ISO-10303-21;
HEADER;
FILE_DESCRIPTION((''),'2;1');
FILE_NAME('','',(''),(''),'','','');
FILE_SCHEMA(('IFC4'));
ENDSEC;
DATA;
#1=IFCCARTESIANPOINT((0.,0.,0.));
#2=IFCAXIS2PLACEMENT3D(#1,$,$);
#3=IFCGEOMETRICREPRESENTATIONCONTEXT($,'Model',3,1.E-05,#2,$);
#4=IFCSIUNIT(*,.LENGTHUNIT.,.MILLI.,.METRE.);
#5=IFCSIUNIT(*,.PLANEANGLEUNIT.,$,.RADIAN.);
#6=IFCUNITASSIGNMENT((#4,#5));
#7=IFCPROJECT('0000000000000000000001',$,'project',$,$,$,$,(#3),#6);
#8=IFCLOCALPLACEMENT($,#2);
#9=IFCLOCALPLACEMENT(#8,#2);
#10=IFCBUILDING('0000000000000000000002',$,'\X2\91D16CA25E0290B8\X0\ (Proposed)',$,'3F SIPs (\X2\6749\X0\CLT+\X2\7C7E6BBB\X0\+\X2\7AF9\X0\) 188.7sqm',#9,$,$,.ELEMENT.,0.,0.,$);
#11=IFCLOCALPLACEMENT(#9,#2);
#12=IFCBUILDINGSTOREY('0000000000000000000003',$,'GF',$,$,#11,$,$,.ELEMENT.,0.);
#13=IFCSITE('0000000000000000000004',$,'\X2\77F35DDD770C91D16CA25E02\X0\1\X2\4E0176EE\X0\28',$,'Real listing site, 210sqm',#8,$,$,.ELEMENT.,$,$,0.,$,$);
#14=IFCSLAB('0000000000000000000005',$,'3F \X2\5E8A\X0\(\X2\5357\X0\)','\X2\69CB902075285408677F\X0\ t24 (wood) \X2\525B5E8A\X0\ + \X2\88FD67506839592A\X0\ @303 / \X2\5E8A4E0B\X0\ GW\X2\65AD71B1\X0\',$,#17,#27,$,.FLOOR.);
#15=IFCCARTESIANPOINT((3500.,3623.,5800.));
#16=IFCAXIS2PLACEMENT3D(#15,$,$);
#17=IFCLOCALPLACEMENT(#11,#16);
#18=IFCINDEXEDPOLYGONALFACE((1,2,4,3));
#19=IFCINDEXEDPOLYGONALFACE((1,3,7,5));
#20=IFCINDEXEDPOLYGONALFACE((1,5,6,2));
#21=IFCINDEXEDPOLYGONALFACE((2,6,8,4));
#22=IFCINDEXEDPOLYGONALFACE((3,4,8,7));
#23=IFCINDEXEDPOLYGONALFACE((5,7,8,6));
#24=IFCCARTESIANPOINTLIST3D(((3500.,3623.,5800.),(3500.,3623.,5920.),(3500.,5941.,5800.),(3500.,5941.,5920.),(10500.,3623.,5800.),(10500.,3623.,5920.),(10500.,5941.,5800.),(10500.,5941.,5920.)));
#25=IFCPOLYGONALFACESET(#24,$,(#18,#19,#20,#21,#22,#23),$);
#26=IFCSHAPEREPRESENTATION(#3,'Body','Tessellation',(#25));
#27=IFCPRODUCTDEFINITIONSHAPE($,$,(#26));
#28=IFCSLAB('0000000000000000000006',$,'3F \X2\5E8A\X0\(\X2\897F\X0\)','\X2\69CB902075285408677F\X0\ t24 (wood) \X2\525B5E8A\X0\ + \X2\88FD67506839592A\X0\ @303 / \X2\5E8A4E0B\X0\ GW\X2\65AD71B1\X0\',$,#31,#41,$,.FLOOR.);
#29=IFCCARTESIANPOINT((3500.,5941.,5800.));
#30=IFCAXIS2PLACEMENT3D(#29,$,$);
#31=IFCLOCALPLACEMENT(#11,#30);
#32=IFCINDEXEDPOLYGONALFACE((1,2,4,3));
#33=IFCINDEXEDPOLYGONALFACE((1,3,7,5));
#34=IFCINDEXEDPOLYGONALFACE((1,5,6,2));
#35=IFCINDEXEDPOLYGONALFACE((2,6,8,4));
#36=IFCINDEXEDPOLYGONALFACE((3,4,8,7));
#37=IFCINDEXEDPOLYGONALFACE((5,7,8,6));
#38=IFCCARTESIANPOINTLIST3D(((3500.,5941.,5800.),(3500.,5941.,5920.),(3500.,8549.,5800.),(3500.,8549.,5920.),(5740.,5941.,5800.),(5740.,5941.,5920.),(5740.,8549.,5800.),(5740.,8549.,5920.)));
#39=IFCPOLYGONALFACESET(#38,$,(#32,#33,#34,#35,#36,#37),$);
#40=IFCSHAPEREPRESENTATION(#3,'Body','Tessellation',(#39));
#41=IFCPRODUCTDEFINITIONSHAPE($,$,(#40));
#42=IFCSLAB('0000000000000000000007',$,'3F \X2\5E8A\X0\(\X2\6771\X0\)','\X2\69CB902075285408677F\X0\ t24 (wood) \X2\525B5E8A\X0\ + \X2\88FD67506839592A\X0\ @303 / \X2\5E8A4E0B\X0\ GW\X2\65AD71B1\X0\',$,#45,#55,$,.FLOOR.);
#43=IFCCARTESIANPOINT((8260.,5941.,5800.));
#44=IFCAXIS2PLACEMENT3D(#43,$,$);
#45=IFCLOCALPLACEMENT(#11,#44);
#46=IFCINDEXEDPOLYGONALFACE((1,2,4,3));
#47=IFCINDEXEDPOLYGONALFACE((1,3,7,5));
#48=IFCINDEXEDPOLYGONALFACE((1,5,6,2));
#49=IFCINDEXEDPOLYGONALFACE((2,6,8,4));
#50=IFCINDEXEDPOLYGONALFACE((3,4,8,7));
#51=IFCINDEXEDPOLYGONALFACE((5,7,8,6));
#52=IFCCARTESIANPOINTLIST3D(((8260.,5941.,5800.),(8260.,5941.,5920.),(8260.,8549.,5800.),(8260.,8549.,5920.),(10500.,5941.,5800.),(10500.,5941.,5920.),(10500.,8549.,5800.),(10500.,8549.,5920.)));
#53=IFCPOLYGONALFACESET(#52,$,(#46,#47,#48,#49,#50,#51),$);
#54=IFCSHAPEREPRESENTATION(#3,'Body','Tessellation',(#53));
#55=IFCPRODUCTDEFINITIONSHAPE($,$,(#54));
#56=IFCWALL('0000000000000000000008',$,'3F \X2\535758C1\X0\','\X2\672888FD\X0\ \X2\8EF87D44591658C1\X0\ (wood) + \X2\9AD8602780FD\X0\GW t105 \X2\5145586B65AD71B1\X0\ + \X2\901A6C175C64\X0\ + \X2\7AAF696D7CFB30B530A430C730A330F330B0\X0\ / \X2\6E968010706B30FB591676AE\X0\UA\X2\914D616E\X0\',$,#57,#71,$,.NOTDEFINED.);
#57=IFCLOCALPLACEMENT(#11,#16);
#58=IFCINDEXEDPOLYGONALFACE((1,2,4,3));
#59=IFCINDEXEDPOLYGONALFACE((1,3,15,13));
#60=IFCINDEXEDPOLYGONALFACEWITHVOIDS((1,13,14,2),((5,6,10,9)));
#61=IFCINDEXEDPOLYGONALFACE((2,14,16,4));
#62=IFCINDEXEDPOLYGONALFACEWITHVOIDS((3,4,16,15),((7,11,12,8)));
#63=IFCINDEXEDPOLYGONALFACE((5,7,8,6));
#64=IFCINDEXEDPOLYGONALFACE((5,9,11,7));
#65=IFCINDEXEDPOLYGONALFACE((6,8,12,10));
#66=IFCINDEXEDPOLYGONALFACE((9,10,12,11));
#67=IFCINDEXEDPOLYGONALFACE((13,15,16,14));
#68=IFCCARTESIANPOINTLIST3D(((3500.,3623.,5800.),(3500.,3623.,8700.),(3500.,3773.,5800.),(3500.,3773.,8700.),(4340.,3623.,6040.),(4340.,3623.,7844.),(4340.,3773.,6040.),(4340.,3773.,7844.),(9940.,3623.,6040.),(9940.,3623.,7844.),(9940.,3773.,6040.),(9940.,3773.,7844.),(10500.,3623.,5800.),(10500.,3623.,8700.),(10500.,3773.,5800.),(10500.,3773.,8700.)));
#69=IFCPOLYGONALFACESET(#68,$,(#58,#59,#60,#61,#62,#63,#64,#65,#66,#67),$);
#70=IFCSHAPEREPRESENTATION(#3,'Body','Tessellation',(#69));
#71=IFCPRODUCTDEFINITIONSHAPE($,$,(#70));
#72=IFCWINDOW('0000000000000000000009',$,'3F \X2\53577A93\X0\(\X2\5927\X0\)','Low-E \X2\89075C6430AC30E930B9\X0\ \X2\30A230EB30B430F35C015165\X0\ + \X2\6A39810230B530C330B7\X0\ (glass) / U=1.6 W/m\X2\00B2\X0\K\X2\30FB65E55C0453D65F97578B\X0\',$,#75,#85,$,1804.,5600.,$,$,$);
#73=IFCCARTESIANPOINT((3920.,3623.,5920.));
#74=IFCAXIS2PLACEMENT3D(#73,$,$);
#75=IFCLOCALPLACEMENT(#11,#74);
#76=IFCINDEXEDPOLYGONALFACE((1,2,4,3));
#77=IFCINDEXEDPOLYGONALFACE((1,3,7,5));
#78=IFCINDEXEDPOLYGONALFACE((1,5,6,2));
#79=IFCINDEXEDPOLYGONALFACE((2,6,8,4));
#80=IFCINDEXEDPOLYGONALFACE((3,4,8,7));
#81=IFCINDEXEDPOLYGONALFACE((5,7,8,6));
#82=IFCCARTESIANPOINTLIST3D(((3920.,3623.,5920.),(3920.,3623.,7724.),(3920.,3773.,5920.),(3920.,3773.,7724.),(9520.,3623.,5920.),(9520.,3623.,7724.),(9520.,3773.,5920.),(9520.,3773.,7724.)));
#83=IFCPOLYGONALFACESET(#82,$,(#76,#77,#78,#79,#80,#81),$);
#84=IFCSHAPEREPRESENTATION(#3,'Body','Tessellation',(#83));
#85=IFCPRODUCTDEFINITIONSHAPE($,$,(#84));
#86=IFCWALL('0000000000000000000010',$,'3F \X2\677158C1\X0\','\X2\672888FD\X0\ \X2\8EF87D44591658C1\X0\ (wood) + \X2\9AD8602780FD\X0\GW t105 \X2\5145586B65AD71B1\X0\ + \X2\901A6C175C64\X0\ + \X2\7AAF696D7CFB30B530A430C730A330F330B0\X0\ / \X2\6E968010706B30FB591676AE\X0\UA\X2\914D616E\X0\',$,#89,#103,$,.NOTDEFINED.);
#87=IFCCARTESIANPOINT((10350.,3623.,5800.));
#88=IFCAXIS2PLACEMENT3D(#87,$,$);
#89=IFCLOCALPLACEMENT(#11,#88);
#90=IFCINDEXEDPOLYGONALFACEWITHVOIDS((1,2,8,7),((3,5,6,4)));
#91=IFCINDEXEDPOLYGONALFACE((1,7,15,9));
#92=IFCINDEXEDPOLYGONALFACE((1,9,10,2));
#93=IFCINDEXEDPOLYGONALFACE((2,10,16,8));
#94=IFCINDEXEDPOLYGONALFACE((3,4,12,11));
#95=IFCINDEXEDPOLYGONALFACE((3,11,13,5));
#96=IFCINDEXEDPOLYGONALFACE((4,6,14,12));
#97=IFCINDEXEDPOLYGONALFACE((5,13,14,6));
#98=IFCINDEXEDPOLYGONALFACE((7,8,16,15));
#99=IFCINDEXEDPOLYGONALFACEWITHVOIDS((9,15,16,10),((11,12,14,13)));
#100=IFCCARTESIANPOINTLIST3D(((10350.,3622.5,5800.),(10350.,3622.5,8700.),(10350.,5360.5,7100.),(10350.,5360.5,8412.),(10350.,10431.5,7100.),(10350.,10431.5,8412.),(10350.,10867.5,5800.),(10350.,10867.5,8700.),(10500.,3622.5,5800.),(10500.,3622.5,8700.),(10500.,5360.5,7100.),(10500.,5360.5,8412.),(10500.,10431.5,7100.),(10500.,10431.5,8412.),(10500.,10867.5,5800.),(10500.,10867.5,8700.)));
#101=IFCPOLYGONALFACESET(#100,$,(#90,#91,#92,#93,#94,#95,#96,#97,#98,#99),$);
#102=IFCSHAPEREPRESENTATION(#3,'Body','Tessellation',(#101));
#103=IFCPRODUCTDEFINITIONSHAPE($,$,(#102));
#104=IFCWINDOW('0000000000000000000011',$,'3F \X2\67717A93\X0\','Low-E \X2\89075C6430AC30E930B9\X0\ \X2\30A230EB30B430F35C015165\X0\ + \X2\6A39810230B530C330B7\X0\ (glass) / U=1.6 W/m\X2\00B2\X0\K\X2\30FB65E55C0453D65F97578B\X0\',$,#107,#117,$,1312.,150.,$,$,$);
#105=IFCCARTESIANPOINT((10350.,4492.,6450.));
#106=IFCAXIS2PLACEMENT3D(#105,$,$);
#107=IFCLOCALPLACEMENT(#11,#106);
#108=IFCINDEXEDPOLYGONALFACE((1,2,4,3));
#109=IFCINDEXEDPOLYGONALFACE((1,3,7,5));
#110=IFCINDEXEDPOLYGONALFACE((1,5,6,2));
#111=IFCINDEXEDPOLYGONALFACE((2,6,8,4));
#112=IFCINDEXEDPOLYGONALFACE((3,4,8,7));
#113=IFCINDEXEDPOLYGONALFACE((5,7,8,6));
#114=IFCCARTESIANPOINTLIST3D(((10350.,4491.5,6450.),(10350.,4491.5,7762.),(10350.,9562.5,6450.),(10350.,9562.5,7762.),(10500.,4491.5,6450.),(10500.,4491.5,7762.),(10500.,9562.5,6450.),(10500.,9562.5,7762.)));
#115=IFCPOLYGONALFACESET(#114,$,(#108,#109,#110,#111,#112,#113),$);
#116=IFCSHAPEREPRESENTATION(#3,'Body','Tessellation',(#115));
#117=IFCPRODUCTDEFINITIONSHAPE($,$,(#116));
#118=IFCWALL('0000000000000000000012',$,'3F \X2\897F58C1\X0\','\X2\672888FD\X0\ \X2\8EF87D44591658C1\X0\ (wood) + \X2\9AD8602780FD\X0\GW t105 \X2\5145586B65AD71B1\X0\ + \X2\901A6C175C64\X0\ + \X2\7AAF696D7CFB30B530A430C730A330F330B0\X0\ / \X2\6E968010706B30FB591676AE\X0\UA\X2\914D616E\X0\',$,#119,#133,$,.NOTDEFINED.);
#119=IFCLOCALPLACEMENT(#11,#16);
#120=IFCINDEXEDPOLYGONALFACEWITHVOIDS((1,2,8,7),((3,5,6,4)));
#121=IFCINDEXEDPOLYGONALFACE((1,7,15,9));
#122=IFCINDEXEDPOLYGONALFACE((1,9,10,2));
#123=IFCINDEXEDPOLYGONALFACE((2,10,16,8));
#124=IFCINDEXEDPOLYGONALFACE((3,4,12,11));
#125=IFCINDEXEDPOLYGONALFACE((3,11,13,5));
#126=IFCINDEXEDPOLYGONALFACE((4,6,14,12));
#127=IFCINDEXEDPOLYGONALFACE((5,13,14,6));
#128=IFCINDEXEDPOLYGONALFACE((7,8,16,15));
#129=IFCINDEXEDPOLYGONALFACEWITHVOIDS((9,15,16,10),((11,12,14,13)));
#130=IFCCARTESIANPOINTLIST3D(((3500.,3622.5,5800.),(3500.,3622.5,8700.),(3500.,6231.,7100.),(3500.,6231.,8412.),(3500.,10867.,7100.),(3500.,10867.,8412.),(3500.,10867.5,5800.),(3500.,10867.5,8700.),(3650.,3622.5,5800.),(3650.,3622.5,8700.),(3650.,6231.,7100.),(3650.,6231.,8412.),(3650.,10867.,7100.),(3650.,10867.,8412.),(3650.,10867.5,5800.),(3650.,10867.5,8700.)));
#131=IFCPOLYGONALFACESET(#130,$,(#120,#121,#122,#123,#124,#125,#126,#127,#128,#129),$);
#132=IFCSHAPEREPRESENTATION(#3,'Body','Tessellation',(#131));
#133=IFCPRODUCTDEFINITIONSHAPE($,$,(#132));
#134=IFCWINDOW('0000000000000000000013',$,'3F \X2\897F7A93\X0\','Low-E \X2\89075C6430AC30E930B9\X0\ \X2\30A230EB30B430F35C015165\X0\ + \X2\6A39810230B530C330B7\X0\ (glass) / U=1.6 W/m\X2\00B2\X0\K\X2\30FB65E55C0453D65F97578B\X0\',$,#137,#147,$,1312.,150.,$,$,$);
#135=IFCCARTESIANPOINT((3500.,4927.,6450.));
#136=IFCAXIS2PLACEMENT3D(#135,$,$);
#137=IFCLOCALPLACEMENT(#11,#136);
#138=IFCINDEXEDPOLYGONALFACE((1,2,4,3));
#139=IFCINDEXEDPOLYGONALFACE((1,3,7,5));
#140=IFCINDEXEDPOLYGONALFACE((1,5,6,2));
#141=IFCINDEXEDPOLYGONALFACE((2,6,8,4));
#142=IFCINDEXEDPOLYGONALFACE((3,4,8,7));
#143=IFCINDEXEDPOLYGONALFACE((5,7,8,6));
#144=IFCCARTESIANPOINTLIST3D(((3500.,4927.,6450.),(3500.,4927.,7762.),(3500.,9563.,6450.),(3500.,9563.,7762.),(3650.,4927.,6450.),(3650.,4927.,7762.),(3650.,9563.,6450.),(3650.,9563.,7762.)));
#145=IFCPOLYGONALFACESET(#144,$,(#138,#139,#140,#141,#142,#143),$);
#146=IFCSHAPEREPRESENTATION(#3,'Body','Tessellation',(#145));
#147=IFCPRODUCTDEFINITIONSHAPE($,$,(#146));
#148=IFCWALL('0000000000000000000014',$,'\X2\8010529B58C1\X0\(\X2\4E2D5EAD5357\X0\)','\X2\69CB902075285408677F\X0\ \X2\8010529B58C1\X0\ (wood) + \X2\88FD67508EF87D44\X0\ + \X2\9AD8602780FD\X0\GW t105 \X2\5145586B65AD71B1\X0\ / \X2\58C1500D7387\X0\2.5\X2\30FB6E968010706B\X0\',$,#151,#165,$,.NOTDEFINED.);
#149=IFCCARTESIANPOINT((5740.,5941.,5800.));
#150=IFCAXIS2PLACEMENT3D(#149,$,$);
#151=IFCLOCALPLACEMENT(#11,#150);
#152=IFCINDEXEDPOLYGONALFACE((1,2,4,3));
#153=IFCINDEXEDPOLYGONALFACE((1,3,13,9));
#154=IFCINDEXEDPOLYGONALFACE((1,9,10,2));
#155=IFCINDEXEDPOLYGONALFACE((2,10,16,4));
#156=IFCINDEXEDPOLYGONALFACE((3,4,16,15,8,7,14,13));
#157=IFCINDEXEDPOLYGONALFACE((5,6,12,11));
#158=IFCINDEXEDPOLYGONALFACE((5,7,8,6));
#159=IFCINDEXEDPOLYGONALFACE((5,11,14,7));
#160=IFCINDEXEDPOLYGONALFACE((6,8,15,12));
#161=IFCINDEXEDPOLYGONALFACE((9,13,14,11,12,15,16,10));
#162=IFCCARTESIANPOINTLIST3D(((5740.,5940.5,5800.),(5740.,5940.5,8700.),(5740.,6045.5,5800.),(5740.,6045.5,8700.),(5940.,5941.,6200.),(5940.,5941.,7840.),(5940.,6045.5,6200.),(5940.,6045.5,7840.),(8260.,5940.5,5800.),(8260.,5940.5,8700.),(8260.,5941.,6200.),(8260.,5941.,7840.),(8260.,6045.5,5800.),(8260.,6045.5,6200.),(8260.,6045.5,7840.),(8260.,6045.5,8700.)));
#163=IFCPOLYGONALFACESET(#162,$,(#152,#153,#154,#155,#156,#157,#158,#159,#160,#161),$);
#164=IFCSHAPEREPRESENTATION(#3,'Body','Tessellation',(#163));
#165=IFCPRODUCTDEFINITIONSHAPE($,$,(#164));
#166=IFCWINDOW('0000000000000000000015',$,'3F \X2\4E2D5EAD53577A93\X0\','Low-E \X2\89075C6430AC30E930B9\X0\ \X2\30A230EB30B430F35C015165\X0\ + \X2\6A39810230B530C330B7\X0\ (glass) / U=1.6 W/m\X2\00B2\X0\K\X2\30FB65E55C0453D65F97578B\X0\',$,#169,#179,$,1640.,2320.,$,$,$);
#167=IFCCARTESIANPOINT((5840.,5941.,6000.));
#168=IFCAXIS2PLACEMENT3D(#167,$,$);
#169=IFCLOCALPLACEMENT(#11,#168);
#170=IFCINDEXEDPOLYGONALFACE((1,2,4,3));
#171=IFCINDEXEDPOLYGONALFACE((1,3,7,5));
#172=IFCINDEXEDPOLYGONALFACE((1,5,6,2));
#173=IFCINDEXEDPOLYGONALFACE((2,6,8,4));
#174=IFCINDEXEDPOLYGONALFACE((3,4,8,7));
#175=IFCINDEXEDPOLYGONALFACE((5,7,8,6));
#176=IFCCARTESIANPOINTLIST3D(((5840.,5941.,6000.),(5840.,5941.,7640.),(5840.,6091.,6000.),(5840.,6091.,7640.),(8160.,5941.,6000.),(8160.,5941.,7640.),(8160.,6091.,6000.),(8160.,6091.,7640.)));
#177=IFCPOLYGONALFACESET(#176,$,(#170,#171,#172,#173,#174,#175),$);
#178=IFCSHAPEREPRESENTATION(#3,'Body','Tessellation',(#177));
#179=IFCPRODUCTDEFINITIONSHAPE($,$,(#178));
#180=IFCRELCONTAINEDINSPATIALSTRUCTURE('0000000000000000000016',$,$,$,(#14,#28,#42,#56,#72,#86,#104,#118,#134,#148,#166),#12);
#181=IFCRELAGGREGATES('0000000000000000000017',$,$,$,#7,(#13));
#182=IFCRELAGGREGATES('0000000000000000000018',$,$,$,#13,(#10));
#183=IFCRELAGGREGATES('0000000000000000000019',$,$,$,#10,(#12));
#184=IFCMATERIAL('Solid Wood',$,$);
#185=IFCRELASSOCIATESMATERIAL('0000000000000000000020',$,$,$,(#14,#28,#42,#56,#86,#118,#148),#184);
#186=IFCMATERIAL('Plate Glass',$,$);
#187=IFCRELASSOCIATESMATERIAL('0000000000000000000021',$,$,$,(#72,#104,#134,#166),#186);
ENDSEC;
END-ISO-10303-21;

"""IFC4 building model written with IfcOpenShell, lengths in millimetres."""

from ifc_helpers import new_model, si_unit, frame, frame_2d, origin, place, context, project, spatial, rectangle, extrude, material, element, fill, save


model = new_model("IFC4")

# Units and contexts
model_context = context("Model", 3, precision=1e-05, world=origin())
ifc_project = project(units=[si_unit("LENGTHUNIT", "METRE", prefix="MILLI"), si_unit("PLANEANGLEUNIT", "RADIAN")], contexts=[model_context])

# Site, building, storey
site_placement = place(None, origin())
site = spatial("IfcSite", under=ifc_project, at=site_placement, Name="石川県金沢市1丁目28", ObjectType="Real listing site, 210sqm", CompositionType="ELEMENT", RefElevation=0.0)
building_placement = place(site_placement, origin())
building = spatial("IfcBuilding", under=site, at=building_placement, Name="金沢市邸 (Proposed)", ObjectType="3F SIPs (杉CLT+籾殻+竹) 188.7sqm", CompositionType="ELEMENT", ElevationOfRefHeight=0.0, ElevationOfTerrain=0.0)
storey_placement = place(building_placement, origin())
storey = spatial("IfcBuildingStorey", under=building, at=storey_placement, Name="GF", CompositionType="ELEMENT", Elevation=0.0)

# Slabs
ifc_material_1 = material(Name="Solid Wood")
slab_1_placement = place(storey_placement, frame((3500.0, 3623.0, 5800.0)))
element("IfcSlab", 1, at=slab_1_placement, inside=storey, material=ifc_material_1, Name="3F 床(南)", Description="構造用合板 t24 (wood) 剛床 + 製材根太 @303 / 床下 GW断熱", PredefinedType="FLOOR", context=model_context, shape_type="SweptSolid", body=[
    extrude(rectangle(XDim=7000.0, YDim=2318.0, at=frame_2d((3500.0, 1159.0))), frame((3500.0, 3623.0, 5800.0)), (0.0, 0.0, 1.0), 120.0),
])
slab_2_placement = place(storey_placement, frame((3500.0, 5941.0, 5800.0)))
element("IfcSlab", 2, at=slab_2_placement, inside=storey, material=ifc_material_1, Name="3F 床(西)", Description="構造用合板 t24 (wood) 剛床 + 製材根太 @303 / 床下 GW断熱", PredefinedType="FLOOR", context=model_context, shape_type="SweptSolid", body=[
    extrude(rectangle(XDim=2240.0, YDim=2608.0, at=frame_2d((1120.0, 1304.0))), frame((3500.0, 5941.0, 5800.0)), (0.0, 0.0, 1.0), 120.0),
])
slab_3_placement = place(storey_placement, frame((8260.0, 5941.0, 5800.0)))
element("IfcSlab", 3, at=slab_3_placement, inside=storey, material=ifc_material_1, Name="3F 床(東)", Description="構造用合板 t24 (wood) 剛床 + 製材根太 @303 / 床下 GW断熱", PredefinedType="FLOOR", context=model_context, shape_type="SweptSolid", body=[
    extrude(rectangle(XDim=2240.0, YDim=2608.0, at=frame_2d((1120.0, 1304.0))), frame((8260.0, 5941.0, 5800.0)), (0.0, 0.0, 1.0), 120.0),
])

# Walls, openings, windows
wall_1_placement = place(storey_placement, frame((3500.0, 3623.0, 5800.0)))
wall_1 = element("IfcWall", 4, at=wall_1_placement, inside=storey, material=ifc_material_1, Name="3F 南壁", Description="木製 軸組外壁 (wood) + 高性能GW t105 充填断熱 + 通気層 + 窯業系サイディング / 準耐火・外皮UA配慮", PredefinedType="NOTDEFINED", context=model_context, shape_type="SweptSolid", body=[
    extrude(rectangle(XDim=7000.0, YDim=150.0, at=frame_2d((3500.0, 75.0))), frame((3500.0, 3623.0, 5800.0)), (0.0, 0.0, 1.0), 2900.0),
])
opening_1_placement = place(storey_placement, frame((3920.0, 3623.0, 5920.0)))
opening_1 = element("IfcOpeningElement", 5, at=opening_1_placement, cuts=wall_1, PredefinedType="NOTDEFINED", context=model_context, shape_type="SweptSolid", body=[
    extrude(rectangle(XDim=5600.0, YDim=150.0, at=frame_2d((2800.0, 75.0))), frame((3920.0, 3623.0, 5920.0)), (0.0, 0.0, 1.0), 1804.0),
])
ifc_material_2 = material(Name="Plate Glass")
window_1_placement = place(storey_placement, frame((3920.0, 3623.0, 5920.0)))
window_1 = element("IfcWindow", 6, at=window_1_placement, inside=storey, material=ifc_material_2, Name="3F 南窓(大)", Description="Low-E 複層ガラス アルゴン封入 + 樹脂サッシ (glass) / U=1.6 W/m²K・日射取得型", OverallHeight=1804.0, OverallWidth=5600.0, context=model_context, shape_type="SweptSolid", body=[
    extrude(rectangle(XDim=5600.0, YDim=150.0, at=frame_2d((2800.0, 75.0))), frame((3920.0, 3623.0, 5920.0)), (0.0, 0.0, 1.0), 1804.0),
])
fill(opening_1, window_1)
wall_2_placement = place(storey_placement, frame((10350.0, 3623.0, 5800.0)))
wall_2 = element("IfcWall", 7, at=wall_2_placement, inside=storey, material=ifc_material_1, Name="3F 東壁", Description="木製 軸組外壁 (wood) + 高性能GW t105 充填断熱 + 通気層 + 窯業系サイディング / 準耐火・外皮UA配慮", PredefinedType="NOTDEFINED", context=model_context, shape_type="SweptSolid", body=[
    extrude(rectangle(XDim=150.0, YDim=7245.0, at=frame_2d((75.0, 3622.0))), frame((10350.0, 3623.0, 5800.0)), (0.0, 0.0, 1.0), 2900.0),
])
opening_2_placement = place(storey_placement, frame((10350.0, 4492.0, 6450.0)))
opening_2 = element("IfcOpeningElement", 8, at=opening_2_placement, cuts=wall_2, PredefinedType="NOTDEFINED", context=model_context, shape_type="SweptSolid", body=[
    extrude(rectangle(XDim=150.0, YDim=5071.0, at=frame_2d((75.0, 2535.0))), frame((10350.0, 4492.0, 6450.0)), (0.0, 0.0, 1.0), 1312.0),
])
window_2_placement = place(storey_placement, frame((10350.0, 4492.0, 6450.0)))
window_2 = element("IfcWindow", 9, at=window_2_placement, inside=storey, material=ifc_material_2, Name="3F 東窓", Description="Low-E 複層ガラス アルゴン封入 + 樹脂サッシ (glass) / U=1.6 W/m²K・日射取得型", OverallHeight=1312.0, OverallWidth=150.0, context=model_context, shape_type="SweptSolid", body=[
    extrude(rectangle(XDim=150.0, YDim=5071.0, at=frame_2d((75.0, 2535.0))), frame((10350.0, 4492.0, 6450.0)), (0.0, 0.0, 1.0), 1312.0),
])
fill(opening_2, window_2)
wall_3_placement = place(storey_placement, frame((3500.0, 3623.0, 5800.0)))
wall_3 = element("IfcWall", 10, at=wall_3_placement, inside=storey, material=ifc_material_1, Name="3F 西壁", Description="木製 軸組外壁 (wood) + 高性能GW t105 充填断熱 + 通気層 + 窯業系サイディング / 準耐火・外皮UA配慮", PredefinedType="NOTDEFINED", context=model_context, shape_type="SweptSolid", body=[
    extrude(rectangle(XDim=150.0, YDim=7245.0, at=frame_2d((75.0, 3622.0))), frame((3500.0, 3623.0, 5800.0)), (0.0, 0.0, 1.0), 2900.0),
])
opening_3_placement = place(storey_placement, frame((3500.0, 4927.0, 6450.0)))
opening_3 = element("IfcOpeningElement", 11, at=opening_3_placement, cuts=wall_3, PredefinedType="NOTDEFINED", context=model_context, shape_type="SweptSolid", body=[
    extrude(rectangle(XDim=150.0, YDim=4636.0, at=frame_2d((75.0, 2318.0))), frame((3500.0, 4927.0, 6450.0)), (0.0, 0.0, 1.0), 1312.0),
])
window_3_placement = place(storey_placement, frame((3500.0, 4927.0, 6450.0)))
window_3 = element("IfcWindow", 12, at=window_3_placement, inside=storey, material=ifc_material_2, Name="3F 西窓", Description="Low-E 複層ガラス アルゴン封入 + 樹脂サッシ (glass) / U=1.6 W/m²K・日射取得型", OverallHeight=1312.0, OverallWidth=150.0, context=model_context, shape_type="SweptSolid", body=[
    extrude(rectangle(XDim=150.0, YDim=4636.0, at=frame_2d((75.0, 2318.0))), frame((3500.0, 4927.0, 6450.0)), (0.0, 0.0, 1.0), 1312.0),
])
fill(opening_3, window_3)
wall_4_placement = place(storey_placement, frame((5740.0, 5941.0, 5800.0)))
wall_4 = element("IfcWall", 13, at=wall_4_placement, inside=storey, material=ifc_material_1, Name="耐力壁(中庭南)", Description="構造用合板 耐力壁 (wood) + 製材軸組 + 高性能GW t105 充填断熱 / 壁倍率2.5・準耐火", PredefinedType="NOTDEFINED", context=model_context, shape_type="SweptSolid", body=[
    extrude(rectangle(XDim=2520.0, YDim=105.0, at=frame_2d((1260.0, 52.0))), frame((5740.0, 5941.0, 5800.0)), (0.0, 0.0, 1.0), 2900.0),
])
opening_4_placement = place(storey_placement, frame((5840.0, 5941.0, 6000.0)))
opening_4 = element("IfcOpeningElement", 14, at=opening_4_placement, cuts=wall_4, PredefinedType="NOTDEFINED", context=model_context, shape_type="SweptSolid", body=[
    extrude(rectangle(XDim=2320.0, YDim=150.0, at=frame_2d((1160.0, 75.0))), frame((5840.0, 5941.0, 6000.0)), (0.0, 0.0, 1.0), 1640.0),
])
window_4_placement = place(storey_placement, frame((5840.0, 5941.0, 6000.0)))
window_4 = element("IfcWindow", 15, at=window_4_placement, inside=storey, material=ifc_material_2, Name="3F 中庭南窓", Description="Low-E 複層ガラス アルゴン封入 + 樹脂サッシ (glass) / U=1.6 W/m²K・日射取得型", OverallHeight=1640.0, OverallWidth=2320.0, context=model_context, shape_type="SweptSolid", body=[
    extrude(rectangle(XDim=2320.0, YDim=150.0, at=frame_2d((1160.0, 75.0))), frame((5840.0, 5941.0, 6000.0)), (0.0, 0.0, 1.0), 1640.0),
])
fill(opening_4, window_4)

save(model, "model.ifc")
